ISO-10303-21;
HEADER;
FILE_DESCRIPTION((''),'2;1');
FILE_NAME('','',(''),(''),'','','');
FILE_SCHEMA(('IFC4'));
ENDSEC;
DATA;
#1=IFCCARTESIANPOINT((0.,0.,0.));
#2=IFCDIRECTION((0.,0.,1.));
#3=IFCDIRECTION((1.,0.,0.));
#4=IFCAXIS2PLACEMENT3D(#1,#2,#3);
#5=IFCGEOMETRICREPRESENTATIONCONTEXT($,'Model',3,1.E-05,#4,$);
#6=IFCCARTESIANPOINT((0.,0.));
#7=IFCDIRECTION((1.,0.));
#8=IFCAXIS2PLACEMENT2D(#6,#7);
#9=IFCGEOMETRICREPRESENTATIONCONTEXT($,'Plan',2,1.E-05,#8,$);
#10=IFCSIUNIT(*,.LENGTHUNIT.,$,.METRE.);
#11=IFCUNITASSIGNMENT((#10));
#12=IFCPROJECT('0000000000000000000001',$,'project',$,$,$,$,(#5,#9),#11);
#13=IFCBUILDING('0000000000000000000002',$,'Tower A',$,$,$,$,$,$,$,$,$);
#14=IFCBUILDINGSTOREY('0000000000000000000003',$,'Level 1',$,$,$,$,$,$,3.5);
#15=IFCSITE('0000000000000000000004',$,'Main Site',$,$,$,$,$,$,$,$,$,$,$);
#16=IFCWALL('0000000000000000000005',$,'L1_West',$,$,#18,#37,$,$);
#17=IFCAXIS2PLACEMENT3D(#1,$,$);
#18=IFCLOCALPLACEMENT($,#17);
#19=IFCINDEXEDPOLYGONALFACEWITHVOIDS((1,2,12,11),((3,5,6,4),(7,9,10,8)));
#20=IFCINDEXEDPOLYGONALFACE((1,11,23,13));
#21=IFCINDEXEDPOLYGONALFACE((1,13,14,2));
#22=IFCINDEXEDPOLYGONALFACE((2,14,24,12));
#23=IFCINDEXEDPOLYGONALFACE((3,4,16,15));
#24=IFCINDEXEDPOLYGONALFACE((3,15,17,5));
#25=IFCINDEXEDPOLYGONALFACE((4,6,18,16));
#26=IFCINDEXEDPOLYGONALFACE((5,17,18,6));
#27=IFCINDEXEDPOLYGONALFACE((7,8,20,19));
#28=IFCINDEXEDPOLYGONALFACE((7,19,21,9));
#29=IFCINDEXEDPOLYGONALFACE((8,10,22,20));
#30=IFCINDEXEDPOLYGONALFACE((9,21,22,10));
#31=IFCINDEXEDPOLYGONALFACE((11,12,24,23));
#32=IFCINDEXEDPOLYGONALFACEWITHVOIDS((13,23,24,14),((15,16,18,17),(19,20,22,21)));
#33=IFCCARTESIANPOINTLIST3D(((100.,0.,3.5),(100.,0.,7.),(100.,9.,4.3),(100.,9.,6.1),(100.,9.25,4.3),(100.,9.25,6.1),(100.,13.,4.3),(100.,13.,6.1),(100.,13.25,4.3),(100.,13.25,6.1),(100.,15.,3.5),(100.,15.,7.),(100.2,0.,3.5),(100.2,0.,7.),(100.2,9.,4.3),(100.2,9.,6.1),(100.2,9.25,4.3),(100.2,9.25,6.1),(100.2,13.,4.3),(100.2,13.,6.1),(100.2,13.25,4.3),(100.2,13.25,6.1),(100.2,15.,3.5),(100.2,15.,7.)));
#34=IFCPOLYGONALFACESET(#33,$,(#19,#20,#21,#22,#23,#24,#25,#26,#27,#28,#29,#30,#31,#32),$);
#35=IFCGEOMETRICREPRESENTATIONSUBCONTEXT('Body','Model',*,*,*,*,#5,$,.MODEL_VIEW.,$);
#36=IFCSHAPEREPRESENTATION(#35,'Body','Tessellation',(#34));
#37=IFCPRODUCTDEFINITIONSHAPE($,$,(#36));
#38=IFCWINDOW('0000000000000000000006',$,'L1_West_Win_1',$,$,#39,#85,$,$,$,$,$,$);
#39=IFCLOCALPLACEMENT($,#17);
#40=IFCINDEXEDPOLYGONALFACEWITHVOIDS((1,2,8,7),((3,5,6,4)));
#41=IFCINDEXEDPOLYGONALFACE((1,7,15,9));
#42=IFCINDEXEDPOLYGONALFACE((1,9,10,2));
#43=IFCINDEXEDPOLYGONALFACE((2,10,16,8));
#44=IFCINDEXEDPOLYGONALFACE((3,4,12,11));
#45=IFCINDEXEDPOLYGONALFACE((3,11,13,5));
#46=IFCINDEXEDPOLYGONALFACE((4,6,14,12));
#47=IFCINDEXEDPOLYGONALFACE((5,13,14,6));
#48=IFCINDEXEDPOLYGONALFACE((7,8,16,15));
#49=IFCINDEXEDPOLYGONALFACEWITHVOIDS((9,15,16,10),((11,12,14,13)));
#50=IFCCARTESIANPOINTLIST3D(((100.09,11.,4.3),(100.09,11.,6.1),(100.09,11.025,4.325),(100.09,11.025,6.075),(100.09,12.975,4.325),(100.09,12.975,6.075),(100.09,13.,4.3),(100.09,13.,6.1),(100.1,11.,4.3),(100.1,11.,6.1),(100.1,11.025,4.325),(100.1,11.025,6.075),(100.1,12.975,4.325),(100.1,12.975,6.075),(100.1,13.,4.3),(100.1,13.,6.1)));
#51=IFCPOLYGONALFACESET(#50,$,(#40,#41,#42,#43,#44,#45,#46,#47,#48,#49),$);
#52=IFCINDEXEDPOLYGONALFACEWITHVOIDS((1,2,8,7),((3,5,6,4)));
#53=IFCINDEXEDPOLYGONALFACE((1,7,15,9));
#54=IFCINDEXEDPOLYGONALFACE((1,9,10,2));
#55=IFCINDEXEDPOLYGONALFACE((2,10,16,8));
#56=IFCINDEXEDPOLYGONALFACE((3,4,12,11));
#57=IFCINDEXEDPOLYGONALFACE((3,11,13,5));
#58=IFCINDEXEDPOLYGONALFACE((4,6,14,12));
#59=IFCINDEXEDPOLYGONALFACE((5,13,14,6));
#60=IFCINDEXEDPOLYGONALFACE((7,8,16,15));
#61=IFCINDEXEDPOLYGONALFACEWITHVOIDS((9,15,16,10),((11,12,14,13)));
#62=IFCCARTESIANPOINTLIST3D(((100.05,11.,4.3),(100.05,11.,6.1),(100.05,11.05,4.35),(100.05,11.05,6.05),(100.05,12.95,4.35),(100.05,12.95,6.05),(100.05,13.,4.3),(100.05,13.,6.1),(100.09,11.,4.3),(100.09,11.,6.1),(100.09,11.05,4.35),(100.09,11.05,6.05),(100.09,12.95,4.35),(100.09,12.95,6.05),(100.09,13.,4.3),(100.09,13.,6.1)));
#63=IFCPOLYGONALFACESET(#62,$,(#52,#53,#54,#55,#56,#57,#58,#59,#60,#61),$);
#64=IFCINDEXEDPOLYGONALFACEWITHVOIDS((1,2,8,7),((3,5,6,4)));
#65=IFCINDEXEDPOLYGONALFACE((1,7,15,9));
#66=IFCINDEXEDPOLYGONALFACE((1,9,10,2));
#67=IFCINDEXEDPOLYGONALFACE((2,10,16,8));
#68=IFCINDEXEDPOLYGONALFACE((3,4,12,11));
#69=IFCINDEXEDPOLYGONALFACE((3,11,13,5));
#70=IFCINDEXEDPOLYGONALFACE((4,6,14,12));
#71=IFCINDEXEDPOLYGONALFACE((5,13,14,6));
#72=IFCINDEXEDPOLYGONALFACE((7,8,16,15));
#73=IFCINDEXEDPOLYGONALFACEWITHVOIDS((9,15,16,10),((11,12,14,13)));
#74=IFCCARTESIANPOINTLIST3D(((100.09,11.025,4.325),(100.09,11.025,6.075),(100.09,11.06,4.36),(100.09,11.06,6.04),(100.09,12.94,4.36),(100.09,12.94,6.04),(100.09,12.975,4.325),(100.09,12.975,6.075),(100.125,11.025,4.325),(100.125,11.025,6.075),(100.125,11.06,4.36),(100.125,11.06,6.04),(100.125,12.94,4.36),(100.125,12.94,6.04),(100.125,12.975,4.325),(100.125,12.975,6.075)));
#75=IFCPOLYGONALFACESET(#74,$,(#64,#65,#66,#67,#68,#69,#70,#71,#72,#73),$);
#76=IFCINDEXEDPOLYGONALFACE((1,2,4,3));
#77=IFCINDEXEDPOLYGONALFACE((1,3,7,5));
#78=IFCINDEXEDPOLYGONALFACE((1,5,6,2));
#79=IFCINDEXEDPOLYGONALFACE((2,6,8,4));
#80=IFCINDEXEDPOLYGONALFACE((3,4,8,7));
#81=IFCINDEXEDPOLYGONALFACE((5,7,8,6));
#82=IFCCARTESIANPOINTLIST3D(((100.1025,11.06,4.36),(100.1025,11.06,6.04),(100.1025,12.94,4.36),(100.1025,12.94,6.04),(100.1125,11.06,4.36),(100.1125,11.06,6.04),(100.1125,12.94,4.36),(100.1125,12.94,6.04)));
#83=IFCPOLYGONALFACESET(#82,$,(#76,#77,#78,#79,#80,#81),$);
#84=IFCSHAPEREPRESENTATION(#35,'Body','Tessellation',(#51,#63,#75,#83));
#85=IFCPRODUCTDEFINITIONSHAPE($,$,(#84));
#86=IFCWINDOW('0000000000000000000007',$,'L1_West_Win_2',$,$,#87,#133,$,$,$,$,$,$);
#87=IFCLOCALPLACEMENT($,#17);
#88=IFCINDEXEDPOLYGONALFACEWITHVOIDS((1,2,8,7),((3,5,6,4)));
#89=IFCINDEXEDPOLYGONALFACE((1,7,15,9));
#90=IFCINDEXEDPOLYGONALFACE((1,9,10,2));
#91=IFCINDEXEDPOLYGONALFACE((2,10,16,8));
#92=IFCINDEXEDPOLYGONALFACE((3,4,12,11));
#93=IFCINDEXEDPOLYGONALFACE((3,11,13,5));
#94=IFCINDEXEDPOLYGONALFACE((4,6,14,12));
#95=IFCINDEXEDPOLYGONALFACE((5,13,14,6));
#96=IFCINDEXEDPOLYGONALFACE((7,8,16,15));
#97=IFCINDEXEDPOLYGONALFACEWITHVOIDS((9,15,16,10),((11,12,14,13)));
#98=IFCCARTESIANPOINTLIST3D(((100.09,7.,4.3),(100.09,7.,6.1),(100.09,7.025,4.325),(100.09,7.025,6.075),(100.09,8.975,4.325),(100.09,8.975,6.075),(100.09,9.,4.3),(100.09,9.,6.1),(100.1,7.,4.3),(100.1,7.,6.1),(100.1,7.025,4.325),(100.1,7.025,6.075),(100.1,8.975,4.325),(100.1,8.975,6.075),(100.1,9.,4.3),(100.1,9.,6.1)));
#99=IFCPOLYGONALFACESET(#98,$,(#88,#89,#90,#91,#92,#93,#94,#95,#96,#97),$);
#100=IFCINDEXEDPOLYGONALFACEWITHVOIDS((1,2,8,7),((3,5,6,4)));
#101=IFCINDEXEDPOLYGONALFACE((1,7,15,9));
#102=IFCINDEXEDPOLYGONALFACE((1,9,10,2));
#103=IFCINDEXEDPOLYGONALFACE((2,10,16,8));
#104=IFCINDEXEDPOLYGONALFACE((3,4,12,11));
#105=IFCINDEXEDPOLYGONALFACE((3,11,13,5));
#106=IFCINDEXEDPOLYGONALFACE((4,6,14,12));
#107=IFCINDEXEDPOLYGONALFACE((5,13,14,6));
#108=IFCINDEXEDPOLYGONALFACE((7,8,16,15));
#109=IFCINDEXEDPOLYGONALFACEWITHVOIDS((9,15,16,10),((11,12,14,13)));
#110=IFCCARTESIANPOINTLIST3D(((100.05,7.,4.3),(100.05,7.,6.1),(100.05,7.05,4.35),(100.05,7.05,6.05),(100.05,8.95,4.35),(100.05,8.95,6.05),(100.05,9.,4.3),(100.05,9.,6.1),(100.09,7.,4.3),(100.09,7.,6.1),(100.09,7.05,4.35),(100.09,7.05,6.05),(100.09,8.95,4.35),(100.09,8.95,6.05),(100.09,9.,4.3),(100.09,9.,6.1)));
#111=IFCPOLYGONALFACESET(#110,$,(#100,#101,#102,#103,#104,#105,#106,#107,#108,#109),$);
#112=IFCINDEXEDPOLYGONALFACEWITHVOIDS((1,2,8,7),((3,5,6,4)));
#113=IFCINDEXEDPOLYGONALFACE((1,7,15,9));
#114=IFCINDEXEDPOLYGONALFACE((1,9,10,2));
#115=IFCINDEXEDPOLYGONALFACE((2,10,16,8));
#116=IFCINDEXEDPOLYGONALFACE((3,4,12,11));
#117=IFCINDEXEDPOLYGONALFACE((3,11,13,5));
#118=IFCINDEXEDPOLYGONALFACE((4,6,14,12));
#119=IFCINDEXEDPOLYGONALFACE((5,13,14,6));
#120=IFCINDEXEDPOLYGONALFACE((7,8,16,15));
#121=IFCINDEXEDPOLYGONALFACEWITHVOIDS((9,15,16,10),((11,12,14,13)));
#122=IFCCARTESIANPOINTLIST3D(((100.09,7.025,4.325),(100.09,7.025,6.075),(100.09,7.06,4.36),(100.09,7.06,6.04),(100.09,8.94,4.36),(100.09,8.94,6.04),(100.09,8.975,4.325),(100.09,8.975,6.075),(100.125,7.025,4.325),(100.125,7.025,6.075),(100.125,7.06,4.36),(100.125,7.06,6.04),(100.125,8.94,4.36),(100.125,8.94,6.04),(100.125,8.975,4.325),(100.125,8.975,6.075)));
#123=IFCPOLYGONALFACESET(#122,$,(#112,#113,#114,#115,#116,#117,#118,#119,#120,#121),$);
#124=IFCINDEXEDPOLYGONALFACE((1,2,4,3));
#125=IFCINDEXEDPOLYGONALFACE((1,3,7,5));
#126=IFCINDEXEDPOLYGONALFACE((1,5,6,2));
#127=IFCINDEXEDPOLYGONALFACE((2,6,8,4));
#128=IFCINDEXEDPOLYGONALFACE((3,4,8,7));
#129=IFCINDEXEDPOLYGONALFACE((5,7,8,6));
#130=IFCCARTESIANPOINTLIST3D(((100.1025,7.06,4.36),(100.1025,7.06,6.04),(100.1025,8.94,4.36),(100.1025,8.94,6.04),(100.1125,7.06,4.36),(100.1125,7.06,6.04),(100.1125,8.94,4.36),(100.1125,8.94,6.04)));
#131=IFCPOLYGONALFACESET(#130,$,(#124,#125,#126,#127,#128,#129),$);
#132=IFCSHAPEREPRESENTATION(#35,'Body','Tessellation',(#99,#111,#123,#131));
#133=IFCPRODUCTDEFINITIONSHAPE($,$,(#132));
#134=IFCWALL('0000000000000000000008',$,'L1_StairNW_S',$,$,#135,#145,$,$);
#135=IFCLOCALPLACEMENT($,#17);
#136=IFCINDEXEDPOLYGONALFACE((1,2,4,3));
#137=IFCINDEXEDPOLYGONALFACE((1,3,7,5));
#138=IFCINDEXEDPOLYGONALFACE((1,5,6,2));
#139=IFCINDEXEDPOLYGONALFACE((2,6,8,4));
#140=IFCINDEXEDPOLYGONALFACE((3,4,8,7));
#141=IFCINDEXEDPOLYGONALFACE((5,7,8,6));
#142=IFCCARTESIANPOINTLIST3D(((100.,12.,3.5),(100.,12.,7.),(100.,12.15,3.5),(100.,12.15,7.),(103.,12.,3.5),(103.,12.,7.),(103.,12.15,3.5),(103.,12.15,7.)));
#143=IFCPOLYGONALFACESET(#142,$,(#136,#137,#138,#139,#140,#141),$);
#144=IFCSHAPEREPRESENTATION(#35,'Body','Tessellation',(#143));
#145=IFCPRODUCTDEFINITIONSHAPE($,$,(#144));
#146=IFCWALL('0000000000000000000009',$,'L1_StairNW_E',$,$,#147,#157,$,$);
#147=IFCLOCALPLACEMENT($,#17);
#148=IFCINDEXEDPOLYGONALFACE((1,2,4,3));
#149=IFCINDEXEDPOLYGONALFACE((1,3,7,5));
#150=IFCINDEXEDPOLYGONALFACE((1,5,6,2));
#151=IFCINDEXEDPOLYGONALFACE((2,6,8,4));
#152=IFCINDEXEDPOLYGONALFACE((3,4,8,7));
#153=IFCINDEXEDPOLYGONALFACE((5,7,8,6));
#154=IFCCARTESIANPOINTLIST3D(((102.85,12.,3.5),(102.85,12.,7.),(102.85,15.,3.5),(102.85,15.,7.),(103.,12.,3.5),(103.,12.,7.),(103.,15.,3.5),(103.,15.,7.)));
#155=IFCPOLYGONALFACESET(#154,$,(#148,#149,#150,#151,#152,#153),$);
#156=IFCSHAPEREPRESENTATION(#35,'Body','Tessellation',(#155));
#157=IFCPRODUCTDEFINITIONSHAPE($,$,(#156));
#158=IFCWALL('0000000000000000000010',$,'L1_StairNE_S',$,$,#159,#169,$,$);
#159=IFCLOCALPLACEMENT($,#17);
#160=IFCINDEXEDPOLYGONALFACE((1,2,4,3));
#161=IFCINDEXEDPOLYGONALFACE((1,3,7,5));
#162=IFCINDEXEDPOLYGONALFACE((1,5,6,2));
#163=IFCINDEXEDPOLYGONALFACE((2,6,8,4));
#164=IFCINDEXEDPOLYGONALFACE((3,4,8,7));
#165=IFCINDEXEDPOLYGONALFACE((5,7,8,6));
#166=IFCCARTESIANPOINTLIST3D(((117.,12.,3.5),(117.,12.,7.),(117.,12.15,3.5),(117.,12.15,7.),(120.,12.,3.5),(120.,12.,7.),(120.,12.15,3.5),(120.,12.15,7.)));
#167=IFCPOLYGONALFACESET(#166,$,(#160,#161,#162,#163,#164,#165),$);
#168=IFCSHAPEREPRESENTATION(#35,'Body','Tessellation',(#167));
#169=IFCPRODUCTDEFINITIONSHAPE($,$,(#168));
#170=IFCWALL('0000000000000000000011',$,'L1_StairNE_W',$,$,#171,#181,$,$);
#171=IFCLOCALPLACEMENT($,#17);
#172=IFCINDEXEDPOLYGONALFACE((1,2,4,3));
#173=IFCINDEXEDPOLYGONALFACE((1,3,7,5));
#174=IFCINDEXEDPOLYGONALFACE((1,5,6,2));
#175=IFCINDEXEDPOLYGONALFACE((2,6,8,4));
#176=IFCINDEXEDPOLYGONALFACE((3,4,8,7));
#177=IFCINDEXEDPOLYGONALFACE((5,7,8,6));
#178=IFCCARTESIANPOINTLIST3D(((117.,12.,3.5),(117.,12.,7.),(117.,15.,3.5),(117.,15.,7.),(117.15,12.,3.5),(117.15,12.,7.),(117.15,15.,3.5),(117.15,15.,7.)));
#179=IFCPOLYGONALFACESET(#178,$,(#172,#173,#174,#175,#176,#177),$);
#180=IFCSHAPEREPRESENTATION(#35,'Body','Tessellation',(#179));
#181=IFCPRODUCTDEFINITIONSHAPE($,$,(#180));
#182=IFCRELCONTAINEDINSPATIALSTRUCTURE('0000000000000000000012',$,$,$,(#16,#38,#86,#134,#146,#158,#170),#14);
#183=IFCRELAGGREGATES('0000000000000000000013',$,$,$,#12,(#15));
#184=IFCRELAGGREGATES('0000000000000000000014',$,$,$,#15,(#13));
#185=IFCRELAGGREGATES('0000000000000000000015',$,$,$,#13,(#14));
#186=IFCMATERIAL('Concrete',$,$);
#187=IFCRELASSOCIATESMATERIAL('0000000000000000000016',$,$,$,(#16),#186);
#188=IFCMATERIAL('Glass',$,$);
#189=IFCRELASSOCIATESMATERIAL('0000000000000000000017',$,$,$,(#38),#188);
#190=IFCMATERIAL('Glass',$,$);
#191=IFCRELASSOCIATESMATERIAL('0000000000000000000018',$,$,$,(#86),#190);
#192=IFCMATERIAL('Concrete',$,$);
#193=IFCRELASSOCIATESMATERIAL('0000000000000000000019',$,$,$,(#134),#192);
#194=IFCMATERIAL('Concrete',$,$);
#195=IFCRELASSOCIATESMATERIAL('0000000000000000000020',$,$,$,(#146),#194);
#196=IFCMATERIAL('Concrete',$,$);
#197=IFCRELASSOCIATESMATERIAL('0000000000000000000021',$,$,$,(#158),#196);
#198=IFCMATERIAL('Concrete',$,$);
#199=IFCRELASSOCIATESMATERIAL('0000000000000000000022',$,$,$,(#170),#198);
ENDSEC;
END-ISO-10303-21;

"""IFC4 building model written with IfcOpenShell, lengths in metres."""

from ifc_helpers import new_model, si_unit, frame, origin_with_axes, origin_2d_with_axis, place, context, subcontext, project, spatial, line, indexed_curve, outline, extrude, material, element, fill, save


model = new_model("IFC4")

# Units and contexts
model_context = context("Model", 3, precision=1e-05, world=origin_with_axes())
plan_context = context("Plan", 2, precision=1e-05, world=origin_2d_with_axis())
body_context = subcontext(model_context, "Body", "Model", "MODEL_VIEW")
ifc_project = project(units=[si_unit("LENGTHUNIT", "METRE")], contexts=[model_context, plan_context])

# Site, building, storey
site = spatial("IfcSite", under=ifc_project, Name="Main Site")
building = spatial("IfcBuilding", under=site, Name="Tower A")
storey = spatial("IfcBuildingStorey", under=building, Name="Level 1", Elevation=3.5)

# Wall, openings, windows
ifc_material_1 = material(Name="Concrete")
wall_1_placement = place(None, frame((100.0, 15.0, 3.5), z_axis=(0.0, 0.0, 1.0), x_axis=(0.0, -1.0, 0.0)))
wall_1 = element("IfcWall", 1, at=wall_1_placement, inside=storey, material=ifc_material_1, Name="L1_West", context=body_context, shape_type="SweptSolid", body=[
    extrude(outline(indexed_curve([(0.0, 0.0), (0.0, 0.2), (15.0, 0.2), (15.0, 0.0), (0.0, 0.0)], self_intersect=False)), origin_with_axes(), (0.0, 0.0, 1.0), 3.5),
])
opening_1_placement = place(wall_1_placement, frame((2.0, 0.0, 0.8), z_axis=(0.0, 0.0, 1.0), x_axis=(0.0, 1.0, 0.0)))
opening_1 = element("IfcOpeningElement", 2, at=opening_1_placement, cuts=wall_1, context=body_context, shape_type="SweptSolid", body=[
    extrude(outline(indexed_curve([(0.0, 0.0), (0.0, 0.25), (2.0, 0.25), (2.0, 0.0), (0.0, 0.0)], self_intersect=False)), origin_with_axes(), (0.0, 0.0, 1.0), 1.8),
])
opening_2_placement = place(wall_1_placement, frame((6.0, 0.0, 0.8), z_axis=(0.0, 0.0, 1.0), x_axis=(0.0, 1.0, 0.0)))
opening_2 = element("IfcOpeningElement", 3, at=opening_2_placement, cuts=wall_1, context=body_context, shape_type="SweptSolid", body=[
    extrude(outline(indexed_curve([(0.0, 0.0), (0.0, 0.25), (2.0, 0.25), (2.0, 0.0), (0.0, 0.0)], self_intersect=False)), origin_with_axes(), (0.0, 0.0, 1.0), 1.8),
])
ifc_material_2 = material(Name="Glass")
window_1_placement = place(None, frame((100.0, 13.0, 4.3), z_axis=(0.0, 0.0, 1.0), x_axis=(0.0, -1.0, 0.0)))
window_1 = element("IfcWindow", 4, at=window_1_placement, inside=storey, material=ifc_material_2, Name="L1_West_Win_1", context=body_context, shape_type="SweptSolid", body=[
    extrude(outline(indexed_curve([(0.0, 0.0), (2.0, 0.0), (2.0, 1.8), (0.0, 1.8)], segments=[line(1, 2, 3, 4, 1)]), holes=[indexed_curve([(0.025, 0.025), (1.975, 0.025), (1.975, 1.775), (0.025, 1.775)], segments=[line(1, 2, 3, 4, 1)])]), frame((0.0, 0.09, 0.0), z_axis=(0.0, -1.0, 0.0), x_axis=(1.0, 0.0, 0.0)), (0.0, 0.0, -1.0), 0.01),
    extrude(outline(indexed_curve([(0.0, 0.0), (2.0, 0.0), (2.0, 1.8), (0.0, 1.8)], segments=[line(1, 2, 3, 4, 1)]), holes=[indexed_curve([(0.05, 0.05), (1.95, 0.05), (1.95, 1.75), (0.05, 1.75)], segments=[line(1, 2, 3, 4, 1)])]), frame((0.0, 0.05, 0.0), z_axis=(0.0, -1.0, 0.0), x_axis=(1.0, 0.0, 0.0)), (0.0, 0.0, -1.0), 0.04),
    extrude(outline(indexed_curve([(0.0, 0.0), (1.95, 0.0), (1.95, 1.75), (0.0, 1.75)], segments=[line(1, 2, 3, 4, 1)]), holes=[indexed_curve([(0.035, 0.035), (1.915, 0.035), (1.915, 1.715), (0.035, 1.715)], segments=[line(1, 2, 3, 4, 1)])]), frame((0.025, 0.09, 0.025), z_axis=(0.0, -1.0, 0.0), x_axis=(1.0, 0.0, 0.0)), (0.0, 0.0, -1.0), 0.035),
    extrude(outline(indexed_curve([(0.035, 0.035), (1.915, 0.035), (1.915, 1.715), (0.035, 1.715)], segments=[line(1, 2, 3, 4, 1)])), frame((0.025, 0.1025, 0.025), z_axis=(0.0, -1.0, 0.0), x_axis=(1.0, 0.0, 0.0)), (0.0, 0.0, -1.0), 0.01),
])
fill(opening_1, window_1)
ifc_material_3 = material(Name="Glass")
window_2_placement = place(None, frame((100.0, 9.0, 4.3), z_axis=(0.0, 0.0, 1.0), x_axis=(0.0, -1.0, 0.0)))
window_2 = element("IfcWindow", 5, at=window_2_placement, inside=storey, material=ifc_material_3, Name="L1_West_Win_2", context=body_context, shape_type="SweptSolid", body=[
    extrude(outline(indexed_curve([(0.0, 0.0), (2.0, 0.0), (2.0, 1.8), (0.0, 1.8)], segments=[line(1, 2, 3, 4, 1)]), holes=[indexed_curve([(0.025, 0.025), (1.975, 0.025), (1.975, 1.775), (0.025, 1.775)], segments=[line(1, 2, 3, 4, 1)])]), frame((0.0, 0.09, 0.0), z_axis=(0.0, -1.0, 0.0), x_axis=(1.0, 0.0, 0.0)), (0.0, 0.0, -1.0), 0.01),
    extrude(outline(indexed_curve([(0.0, 0.0), (2.0, 0.0), (2.0, 1.8), (0.0, 1.8)], segments=[line(1, 2, 3, 4, 1)]), holes=[indexed_curve([(0.05, 0.05), (1.95, 0.05), (1.95, 1.75), (0.05, 1.75)], segments=[line(1, 2, 3, 4, 1)])]), frame((0.0, 0.05, 0.0), z_axis=(0.0, -1.0, 0.0), x_axis=(1.0, 0.0, 0.0)), (0.0, 0.0, -1.0), 0.04),
    extrude(outline(indexed_curve([(0.0, 0.0), (1.95, 0.0), (1.95, 1.75), (0.0, 1.75)], segments=[line(1, 2, 3, 4, 1)]), holes=[indexed_curve([(0.035, 0.035), (1.915, 0.035), (1.915, 1.715), (0.035, 1.715)], segments=[line(1, 2, 3, 4, 1)])]), frame((0.025, 0.09, 0.025), z_axis=(0.0, -1.0, 0.0), x_axis=(1.0, 0.0, 0.0)), (0.0, 0.0, -1.0), 0.035),
    extrude(outline(indexed_curve([(0.035, 0.035), (1.915, 0.035), (1.915, 1.715), (0.035, 1.715)], segments=[line(1, 2, 3, 4, 1)])), frame((0.025, 0.1025, 0.025), z_axis=(0.0, -1.0, 0.0), x_axis=(1.0, 0.0, 0.0)), (0.0, 0.0, -1.0), 0.01),
])
fill(opening_2, window_2)

# Walls
ifc_material_4 = material(Name="Concrete")
wall_2_placement = place(None, frame((100.0, 12.0, 3.5), z_axis=(0.0, 0.0, 1.0), x_axis=(1.0, 0.0, 0.0)))
element("IfcWall", 6, at=wall_2_placement, inside=storey, material=ifc_material_4, Name="L1_StairNW_S", context=body_context, shape_type="SweptSolid", body=[
    extrude(outline(indexed_curve([(0.0, 0.0), (0.0, 0.15), (3.0, 0.15), (3.0, 0.0), (0.0, 0.0)], self_intersect=False)), origin_with_axes(), (0.0, 0.0, 1.0), 3.5),
])
ifc_material_5 = material(Name="Concrete")
wall_3_placement = place(None, frame((103.0, 12.0, 3.5), z_axis=(0.0, 0.0, 1.0), x_axis=(0.0, 1.0, 0.0)))
element("IfcWall", 7, at=wall_3_placement, inside=storey, material=ifc_material_5, Name="L1_StairNW_E", context=body_context, shape_type="SweptSolid", body=[
    extrude(outline(indexed_curve([(0.0, 0.0), (0.0, 0.15), (3.0, 0.15), (3.0, 0.0), (0.0, 0.0)], self_intersect=False)), origin_with_axes(), (0.0, 0.0, 1.0), 3.5),
])
ifc_material_6 = material(Name="Concrete")
wall_4_placement = place(None, frame((117.0, 12.0, 3.5), z_axis=(0.0, 0.0, 1.0), x_axis=(1.0, 0.0, 0.0)))
element("IfcWall", 8, at=wall_4_placement, inside=storey, material=ifc_material_6, Name="L1_StairNE_S", context=body_context, shape_type="SweptSolid", body=[
    extrude(outline(indexed_curve([(0.0, 0.0), (0.0, 0.15), (3.0, 0.15), (3.0, 0.0), (0.0, 0.0)], self_intersect=False)), origin_with_axes(), (0.0, 0.0, 1.0), 3.5),
])
ifc_material_7 = material(Name="Concrete")
wall_5_placement = place(None, frame((117.0, 15.0, 3.5), z_axis=(0.0, 0.0, 1.0), x_axis=(0.0, -1.0, 0.0)))
element("IfcWall", 9, at=wall_5_placement, inside=storey, material=ifc_material_7, Name="L1_StairNE_W", context=body_context, shape_type="SweptSolid", body=[
    extrude(outline(indexed_curve([(0.0, 0.0), (0.0, 0.15), (3.0, 0.15), (3.0, 0.0), (0.0, 0.0)], self_intersect=False)), origin_with_axes(), (0.0, 0.0, 1.0), 3.5),
])

save(model, "model.ifc")
